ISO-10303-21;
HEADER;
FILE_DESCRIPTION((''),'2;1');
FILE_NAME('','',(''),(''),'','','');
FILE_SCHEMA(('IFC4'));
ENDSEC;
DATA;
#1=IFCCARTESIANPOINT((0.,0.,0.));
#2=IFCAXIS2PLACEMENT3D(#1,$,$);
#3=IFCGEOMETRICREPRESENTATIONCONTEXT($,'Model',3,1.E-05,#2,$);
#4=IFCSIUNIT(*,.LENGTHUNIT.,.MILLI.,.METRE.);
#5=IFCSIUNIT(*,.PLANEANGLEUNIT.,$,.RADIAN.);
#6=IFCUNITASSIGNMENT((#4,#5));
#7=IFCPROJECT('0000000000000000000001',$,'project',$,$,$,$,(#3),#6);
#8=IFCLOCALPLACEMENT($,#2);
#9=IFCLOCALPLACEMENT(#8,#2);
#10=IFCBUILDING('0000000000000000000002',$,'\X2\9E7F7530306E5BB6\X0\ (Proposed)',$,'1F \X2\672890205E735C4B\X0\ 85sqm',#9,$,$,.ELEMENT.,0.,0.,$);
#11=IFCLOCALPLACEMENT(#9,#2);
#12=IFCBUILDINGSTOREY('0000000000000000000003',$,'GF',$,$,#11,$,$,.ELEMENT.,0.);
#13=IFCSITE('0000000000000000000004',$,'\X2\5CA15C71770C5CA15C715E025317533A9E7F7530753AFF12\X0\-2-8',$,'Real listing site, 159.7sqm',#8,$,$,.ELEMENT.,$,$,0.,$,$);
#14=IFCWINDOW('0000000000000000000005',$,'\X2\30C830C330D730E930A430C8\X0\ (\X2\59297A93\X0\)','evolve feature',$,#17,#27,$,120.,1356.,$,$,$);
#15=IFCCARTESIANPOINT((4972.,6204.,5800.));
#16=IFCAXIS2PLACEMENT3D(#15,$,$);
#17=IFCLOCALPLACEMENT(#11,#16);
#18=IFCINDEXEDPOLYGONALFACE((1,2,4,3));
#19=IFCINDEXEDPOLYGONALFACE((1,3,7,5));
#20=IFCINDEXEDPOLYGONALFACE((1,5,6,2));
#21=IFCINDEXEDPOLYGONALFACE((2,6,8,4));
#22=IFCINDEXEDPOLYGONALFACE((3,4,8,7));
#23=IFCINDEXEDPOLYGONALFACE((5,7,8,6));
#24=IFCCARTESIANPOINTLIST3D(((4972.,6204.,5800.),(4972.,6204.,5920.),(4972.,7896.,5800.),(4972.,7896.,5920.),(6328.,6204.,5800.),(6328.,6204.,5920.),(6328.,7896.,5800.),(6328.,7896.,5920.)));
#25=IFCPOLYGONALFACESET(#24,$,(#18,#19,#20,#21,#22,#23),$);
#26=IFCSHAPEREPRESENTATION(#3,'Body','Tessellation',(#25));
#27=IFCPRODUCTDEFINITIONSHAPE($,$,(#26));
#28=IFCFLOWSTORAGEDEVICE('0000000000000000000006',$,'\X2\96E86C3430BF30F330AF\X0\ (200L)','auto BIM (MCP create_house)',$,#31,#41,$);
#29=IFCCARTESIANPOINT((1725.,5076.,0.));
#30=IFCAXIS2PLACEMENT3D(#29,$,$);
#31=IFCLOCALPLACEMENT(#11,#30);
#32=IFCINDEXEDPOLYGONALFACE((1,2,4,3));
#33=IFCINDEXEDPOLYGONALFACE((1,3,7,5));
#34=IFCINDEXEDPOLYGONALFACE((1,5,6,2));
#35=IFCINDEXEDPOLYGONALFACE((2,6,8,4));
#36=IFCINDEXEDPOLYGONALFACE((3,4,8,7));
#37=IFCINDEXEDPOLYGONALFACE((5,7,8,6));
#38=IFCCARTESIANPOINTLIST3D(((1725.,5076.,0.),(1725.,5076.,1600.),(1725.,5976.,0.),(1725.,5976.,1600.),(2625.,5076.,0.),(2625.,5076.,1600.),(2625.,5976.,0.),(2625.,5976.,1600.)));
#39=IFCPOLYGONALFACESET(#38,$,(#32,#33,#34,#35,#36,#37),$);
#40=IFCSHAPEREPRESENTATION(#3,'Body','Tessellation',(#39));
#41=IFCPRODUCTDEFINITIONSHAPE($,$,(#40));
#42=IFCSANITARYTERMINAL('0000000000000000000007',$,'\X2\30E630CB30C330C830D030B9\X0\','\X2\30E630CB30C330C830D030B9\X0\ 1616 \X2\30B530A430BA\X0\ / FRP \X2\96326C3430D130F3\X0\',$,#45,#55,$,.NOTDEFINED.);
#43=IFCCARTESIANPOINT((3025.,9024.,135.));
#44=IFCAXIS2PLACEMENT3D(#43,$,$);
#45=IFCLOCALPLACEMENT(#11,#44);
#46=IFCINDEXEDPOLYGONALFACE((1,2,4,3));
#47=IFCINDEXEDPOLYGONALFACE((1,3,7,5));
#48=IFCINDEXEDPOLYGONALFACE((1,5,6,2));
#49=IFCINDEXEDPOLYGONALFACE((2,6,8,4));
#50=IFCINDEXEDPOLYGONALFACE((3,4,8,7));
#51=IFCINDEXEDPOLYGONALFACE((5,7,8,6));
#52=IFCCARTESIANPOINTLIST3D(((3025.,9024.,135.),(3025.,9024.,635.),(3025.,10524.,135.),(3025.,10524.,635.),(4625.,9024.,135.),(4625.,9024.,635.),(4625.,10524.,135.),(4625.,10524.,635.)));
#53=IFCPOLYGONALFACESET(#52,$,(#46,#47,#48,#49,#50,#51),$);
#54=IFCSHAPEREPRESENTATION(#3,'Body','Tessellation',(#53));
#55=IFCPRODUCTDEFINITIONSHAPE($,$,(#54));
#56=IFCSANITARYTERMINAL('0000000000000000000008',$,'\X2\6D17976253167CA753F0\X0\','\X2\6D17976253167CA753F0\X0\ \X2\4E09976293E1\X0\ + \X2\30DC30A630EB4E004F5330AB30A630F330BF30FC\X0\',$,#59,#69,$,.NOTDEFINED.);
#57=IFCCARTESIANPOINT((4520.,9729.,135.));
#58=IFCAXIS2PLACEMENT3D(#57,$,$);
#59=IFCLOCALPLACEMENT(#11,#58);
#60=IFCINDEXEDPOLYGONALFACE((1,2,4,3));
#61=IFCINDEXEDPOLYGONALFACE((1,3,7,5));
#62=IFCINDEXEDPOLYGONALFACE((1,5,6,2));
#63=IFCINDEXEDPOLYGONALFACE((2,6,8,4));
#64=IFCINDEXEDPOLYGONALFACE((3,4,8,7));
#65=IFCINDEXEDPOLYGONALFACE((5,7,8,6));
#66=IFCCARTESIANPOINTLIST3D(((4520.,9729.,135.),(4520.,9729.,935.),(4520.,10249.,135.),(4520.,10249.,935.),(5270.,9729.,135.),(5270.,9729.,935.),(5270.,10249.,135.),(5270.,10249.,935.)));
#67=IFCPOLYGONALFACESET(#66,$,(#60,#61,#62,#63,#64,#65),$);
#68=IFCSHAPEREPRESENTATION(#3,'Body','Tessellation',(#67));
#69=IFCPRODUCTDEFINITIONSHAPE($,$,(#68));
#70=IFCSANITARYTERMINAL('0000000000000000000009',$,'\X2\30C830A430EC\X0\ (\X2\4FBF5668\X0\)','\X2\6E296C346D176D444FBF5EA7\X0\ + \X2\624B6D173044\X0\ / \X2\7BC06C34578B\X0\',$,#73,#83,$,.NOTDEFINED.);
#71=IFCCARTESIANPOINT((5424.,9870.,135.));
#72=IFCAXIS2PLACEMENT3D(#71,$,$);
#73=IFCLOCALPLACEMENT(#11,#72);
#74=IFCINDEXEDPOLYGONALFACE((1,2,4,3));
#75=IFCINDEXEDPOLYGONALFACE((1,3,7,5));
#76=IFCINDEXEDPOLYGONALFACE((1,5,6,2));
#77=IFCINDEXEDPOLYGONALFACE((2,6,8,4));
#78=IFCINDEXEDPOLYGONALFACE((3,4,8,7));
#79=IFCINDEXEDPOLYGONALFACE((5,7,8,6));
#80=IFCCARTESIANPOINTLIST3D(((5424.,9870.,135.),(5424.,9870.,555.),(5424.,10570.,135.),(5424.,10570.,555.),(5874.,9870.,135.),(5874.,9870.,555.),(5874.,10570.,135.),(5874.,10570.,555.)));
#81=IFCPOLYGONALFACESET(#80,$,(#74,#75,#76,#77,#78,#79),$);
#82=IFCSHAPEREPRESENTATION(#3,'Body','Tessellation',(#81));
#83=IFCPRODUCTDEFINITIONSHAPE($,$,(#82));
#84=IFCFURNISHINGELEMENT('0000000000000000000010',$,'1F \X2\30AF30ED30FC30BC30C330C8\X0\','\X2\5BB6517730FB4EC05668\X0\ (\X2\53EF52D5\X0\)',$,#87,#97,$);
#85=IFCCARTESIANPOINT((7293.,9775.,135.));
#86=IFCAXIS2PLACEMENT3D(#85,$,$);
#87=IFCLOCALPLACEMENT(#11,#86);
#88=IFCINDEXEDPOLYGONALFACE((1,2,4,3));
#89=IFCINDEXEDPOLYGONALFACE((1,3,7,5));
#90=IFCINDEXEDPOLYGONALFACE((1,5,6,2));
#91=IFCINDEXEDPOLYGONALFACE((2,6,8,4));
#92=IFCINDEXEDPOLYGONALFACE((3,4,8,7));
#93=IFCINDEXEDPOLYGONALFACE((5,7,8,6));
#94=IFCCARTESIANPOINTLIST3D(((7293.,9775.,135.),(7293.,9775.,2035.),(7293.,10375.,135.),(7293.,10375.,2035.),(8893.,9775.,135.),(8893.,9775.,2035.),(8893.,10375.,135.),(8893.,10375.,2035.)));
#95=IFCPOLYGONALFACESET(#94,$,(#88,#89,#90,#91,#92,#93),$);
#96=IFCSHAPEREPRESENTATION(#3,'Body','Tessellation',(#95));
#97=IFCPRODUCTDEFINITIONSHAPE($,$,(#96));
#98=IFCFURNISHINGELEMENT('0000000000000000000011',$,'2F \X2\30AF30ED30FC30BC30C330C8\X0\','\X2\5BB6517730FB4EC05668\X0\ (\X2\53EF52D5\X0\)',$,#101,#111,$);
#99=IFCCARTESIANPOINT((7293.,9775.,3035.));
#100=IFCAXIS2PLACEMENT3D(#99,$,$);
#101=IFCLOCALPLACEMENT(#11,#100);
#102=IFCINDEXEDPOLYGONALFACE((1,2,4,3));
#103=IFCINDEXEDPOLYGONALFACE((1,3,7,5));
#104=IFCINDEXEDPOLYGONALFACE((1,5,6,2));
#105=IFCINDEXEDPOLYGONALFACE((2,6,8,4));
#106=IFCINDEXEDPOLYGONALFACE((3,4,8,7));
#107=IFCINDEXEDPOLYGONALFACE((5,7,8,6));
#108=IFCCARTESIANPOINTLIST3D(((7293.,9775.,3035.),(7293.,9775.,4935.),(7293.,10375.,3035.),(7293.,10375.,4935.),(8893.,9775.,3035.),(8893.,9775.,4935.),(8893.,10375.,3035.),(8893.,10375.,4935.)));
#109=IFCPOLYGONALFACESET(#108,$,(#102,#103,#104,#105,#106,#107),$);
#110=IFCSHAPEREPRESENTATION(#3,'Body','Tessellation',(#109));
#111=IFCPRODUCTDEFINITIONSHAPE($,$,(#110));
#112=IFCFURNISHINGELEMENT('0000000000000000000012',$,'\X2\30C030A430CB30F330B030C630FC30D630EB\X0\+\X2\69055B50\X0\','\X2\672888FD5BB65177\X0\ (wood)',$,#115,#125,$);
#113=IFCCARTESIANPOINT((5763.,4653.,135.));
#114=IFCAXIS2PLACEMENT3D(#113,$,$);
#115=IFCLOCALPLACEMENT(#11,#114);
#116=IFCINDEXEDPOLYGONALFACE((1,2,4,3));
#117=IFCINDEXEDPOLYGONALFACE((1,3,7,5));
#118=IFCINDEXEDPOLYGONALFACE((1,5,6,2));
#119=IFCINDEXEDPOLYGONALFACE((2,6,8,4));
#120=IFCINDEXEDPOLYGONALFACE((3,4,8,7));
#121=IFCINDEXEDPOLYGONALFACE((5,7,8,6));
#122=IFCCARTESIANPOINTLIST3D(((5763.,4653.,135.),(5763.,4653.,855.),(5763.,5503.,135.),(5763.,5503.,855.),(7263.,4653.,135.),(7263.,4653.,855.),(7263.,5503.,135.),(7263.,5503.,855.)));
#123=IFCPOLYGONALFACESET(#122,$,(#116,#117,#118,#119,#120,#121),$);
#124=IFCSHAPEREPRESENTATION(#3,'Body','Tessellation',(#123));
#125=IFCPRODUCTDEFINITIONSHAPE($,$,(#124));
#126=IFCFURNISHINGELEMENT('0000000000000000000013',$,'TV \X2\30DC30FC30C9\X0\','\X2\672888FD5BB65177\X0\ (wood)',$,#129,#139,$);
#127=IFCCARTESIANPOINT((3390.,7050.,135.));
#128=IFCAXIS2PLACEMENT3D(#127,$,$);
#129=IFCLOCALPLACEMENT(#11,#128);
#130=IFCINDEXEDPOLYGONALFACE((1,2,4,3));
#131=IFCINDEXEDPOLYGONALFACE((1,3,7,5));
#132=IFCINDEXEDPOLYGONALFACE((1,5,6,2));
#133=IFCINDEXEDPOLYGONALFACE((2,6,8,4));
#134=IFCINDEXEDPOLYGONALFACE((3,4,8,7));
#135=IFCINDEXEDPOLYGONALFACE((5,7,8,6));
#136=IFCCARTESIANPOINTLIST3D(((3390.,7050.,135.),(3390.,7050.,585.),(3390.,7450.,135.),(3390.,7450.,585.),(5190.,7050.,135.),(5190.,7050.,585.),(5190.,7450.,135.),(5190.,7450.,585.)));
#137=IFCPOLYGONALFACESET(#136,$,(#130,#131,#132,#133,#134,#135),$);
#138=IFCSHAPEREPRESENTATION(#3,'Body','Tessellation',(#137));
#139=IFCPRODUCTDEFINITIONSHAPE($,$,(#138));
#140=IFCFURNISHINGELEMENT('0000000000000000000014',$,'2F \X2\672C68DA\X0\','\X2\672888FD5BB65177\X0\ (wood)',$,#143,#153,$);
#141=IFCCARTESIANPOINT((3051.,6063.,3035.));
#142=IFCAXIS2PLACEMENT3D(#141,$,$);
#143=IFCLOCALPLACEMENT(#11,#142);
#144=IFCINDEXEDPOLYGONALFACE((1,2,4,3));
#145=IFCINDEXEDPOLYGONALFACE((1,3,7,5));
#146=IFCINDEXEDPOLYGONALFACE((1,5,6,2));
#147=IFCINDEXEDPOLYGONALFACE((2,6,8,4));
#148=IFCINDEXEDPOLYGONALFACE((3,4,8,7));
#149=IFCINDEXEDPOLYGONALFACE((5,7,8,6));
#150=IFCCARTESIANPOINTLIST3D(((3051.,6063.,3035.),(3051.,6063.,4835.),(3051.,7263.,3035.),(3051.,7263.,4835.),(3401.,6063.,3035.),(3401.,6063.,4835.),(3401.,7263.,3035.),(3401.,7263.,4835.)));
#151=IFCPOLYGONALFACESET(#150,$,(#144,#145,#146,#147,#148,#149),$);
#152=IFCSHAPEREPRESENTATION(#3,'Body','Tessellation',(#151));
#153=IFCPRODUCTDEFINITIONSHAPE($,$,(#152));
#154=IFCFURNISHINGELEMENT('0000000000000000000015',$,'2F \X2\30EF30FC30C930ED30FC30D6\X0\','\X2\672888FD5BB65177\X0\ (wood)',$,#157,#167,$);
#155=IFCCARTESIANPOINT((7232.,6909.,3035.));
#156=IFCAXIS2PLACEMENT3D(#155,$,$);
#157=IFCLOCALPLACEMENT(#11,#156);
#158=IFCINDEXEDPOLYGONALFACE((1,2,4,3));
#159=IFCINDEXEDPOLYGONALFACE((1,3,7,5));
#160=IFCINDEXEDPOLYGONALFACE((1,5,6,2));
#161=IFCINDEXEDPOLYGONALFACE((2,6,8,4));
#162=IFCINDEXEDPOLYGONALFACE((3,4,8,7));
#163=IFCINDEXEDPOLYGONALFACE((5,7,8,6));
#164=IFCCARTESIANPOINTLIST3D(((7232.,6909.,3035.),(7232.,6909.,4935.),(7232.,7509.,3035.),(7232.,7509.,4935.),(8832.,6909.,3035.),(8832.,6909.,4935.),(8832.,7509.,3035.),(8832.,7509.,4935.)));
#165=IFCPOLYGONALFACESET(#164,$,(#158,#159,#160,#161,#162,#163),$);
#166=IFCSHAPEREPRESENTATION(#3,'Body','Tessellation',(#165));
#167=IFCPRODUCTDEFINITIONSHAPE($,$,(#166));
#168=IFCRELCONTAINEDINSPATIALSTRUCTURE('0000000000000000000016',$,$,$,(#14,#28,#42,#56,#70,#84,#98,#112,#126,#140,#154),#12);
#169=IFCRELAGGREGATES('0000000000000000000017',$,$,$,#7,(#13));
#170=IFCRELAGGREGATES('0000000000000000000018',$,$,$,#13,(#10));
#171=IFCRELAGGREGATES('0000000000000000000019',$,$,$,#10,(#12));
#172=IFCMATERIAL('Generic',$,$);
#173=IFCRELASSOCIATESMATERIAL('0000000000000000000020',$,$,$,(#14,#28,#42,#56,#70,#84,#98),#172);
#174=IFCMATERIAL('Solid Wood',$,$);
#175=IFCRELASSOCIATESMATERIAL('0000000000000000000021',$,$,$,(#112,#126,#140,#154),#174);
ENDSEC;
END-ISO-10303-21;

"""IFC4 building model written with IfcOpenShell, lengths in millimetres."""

from ifc_helpers import new_model, si_unit, frame, frame_2d, origin, place, context, project, spatial, rectangle, extrude, material, element, save


model = new_model("IFC4")

# Units and contexts
model_context = context("Model", 3, precision=1e-05, world=origin())
ifc_project = project(units=[si_unit("LENGTHUNIT", "METRE", prefix="MILLI"), si_unit("PLANEANGLEUNIT", "RADIAN")], contexts=[model_context])

# Site, building, storey
site_placement = place(None, origin())
site = spatial("IfcSite", under=ifc_project, at=site_placement, Name="岡山県岡山市北区鹿田町２-2-8", ObjectType="Real listing site, 159.7sqm", CompositionType="ELEMENT", RefElevation=0.0)
building_placement = place(site_placement, origin())
building = spatial("IfcBuilding", under=site, at=building_placement, Name="鹿田の家 (Proposed)", ObjectType="1F 木造平屋 85sqm", CompositionType="ELEMENT", ElevationOfRefHeight=0.0, ElevationOfTerrain=0.0)
storey_placement = place(building_placement, origin())
storey = spatial("IfcBuildingStorey", under=building, at=storey_placement, Name="GF", CompositionType="ELEMENT", Elevation=0.0)

# Shared definitions
ifc_material_1 = material(Name="Solid Wood")

# Window
ifc_material_2 = material(Name="Generic")
window_1_placement = place(storey_placement, frame((4972.0, 6204.0, 5800.0)))
element("IfcWindow", 1, at=window_1_placement, inside=storey, material=ifc_material_2, Name="トップライト (天窓)", Description="evolve feature", OverallHeight=120.0, OverallWidth=1356.0, context=model_context, shape_type="SweptSolid", body=[
    extrude(rectangle(XDim=1356.0, YDim=1692.0, at=frame_2d((678.0, 846.0))), frame((4972.0, 6204.0, 5800.0)), (0.0, 0.0, 1.0), 120.0),
])

# Flow storage device
flow_storage_device_placement = place(storey_placement, frame((1725.0, 5076.0, 0.0)))
element("IfcFlowStorageDevice", 2, at=flow_storage_device_placement, inside=storey, material=ifc_material_2, Name="雨水タンク (200L)", Description="auto BIM (MCP create_house)", context=model_context, shape_type="SweptSolid", body=[
    extrude(rectangle(XDim=900.0, YDim=900.0, at=frame_2d((450.0, 450.0))), frame((1725.0, 5076.0, 0.0)), (0.0, 0.0, 1.0), 1600.0),
])

# Sanitary terminals
sanitary_terminal_1_placement = place(storey_placement, frame((3025.0, 9024.0, 135.0)))
element("IfcSanitaryTerminal", 3, at=sanitary_terminal_1_placement, inside=storey, material=ifc_material_2, Name="ユニットバス", Description="ユニットバス 1616 サイズ / FRP 防水パン", PredefinedType="NOTDEFINED", context=model_context, shape_type="SweptSolid", body=[
    extrude(rectangle(XDim=1600.0, YDim=1500.0, at=frame_2d((800.0, 750.0))), frame((3025.0, 9024.0, 135.0)), (0.0, 0.0, 1.0), 500.0),
])
sanitary_terminal_2_placement = place(storey_placement, frame((4520.0, 9729.0, 135.0)))
element("IfcSanitaryTerminal", 4, at=sanitary_terminal_2_placement, inside=storey, material=ifc_material_2, Name="洗面化粧台", Description="洗面化粧台 三面鏡 + ボウル一体カウンター", PredefinedType="NOTDEFINED", context=model_context, shape_type="SweptSolid", body=[
    extrude(rectangle(XDim=750.0, YDim=520.0, at=frame_2d((375.0, 260.0))), frame((4520.0, 9729.0, 135.0)), (0.0, 0.0, 1.0), 800.0),
])
sanitary_terminal_3_placement = place(storey_placement, frame((5424.0, 9870.0, 135.0)))
element("IfcSanitaryTerminal", 5, at=sanitary_terminal_3_placement, inside=storey, material=ifc_material_2, Name="トイレ (便器)", Description="温水洗浄便座 + 手洗い / 節水型", PredefinedType="NOTDEFINED", context=model_context, shape_type="SweptSolid", body=[
    extrude(rectangle(XDim=450.0, YDim=700.0, at=frame_2d((225.0, 350.0))), frame((5424.0, 9870.0, 135.0)), (0.0, 0.0, 1.0), 420.0),
])

# Furnishing elements
furnishing_1_placement = place(storey_placement, frame((7293.0, 9775.0, 135.0)))
element("IfcFurnishingElement", 6, at=furnishing_1_placement, inside=storey, material=ifc_material_2, Name="1F クローゼット", Description="家具・什器 (可動)", context=model_context, shape_type="SweptSolid", body=[
    extrude(rectangle(XDim=1600.0, YDim=600.0, at=frame_2d((800.0, 300.0))), frame((7293.0, 9775.0, 135.0)), (0.0, 0.0, 1.0), 1900.0),
])
furnishing_2_placement = place(storey_placement, frame((7293.0, 9775.0, 3035.0)))
element("IfcFurnishingElement", 7, at=furnishing_2_placement, inside=storey, material=ifc_material_2, Name="2F クローゼット", Description="家具・什器 (可動)", context=model_context, shape_type="SweptSolid", body=[
    extrude(rectangle(XDim=1600.0, YDim=600.0, at=frame_2d((800.0, 300.0))), frame((7293.0, 9775.0, 3035.0)), (0.0, 0.0, 1.0), 1900.0),
])
furnishing_3_placement = place(storey_placement, frame((5763.0, 4653.0, 135.0)))
element("IfcFurnishingElement", 8, at=furnishing_3_placement, inside=storey, material=ifc_material_1, Name="ダイニングテーブル+椅子", Description="木製家具 (wood)", context=model_context, shape_type="SweptSolid", body=[
    extrude(rectangle(XDim=1500.0, YDim=850.0, at=frame_2d((750.0, 425.0))), frame((5763.0, 4653.0, 135.0)), (0.0, 0.0, 1.0), 720.0),
])
furnishing_4_placement = place(storey_placement, frame((3390.0, 7050.0, 135.0)))
element("IfcFurnishingElement", 9, at=furnishing_4_placement, inside=storey, material=ifc_material_1, Name="TV ボード", Description="木製家具 (wood)", context=model_context, shape_type="SweptSolid", body=[
    extrude(rectangle(XDim=1800.0, YDim=400.0, at=frame_2d((900.0, 200.0))), frame((3390.0, 7050.0, 135.0)), (0.0, 0.0, 1.0), 450.0),
])
furnishing_5_placement = place(storey_placement, frame((3051.0, 6063.0, 3035.0)))
element("IfcFurnishingElement", 10, at=furnishing_5_placement, inside=storey, material=ifc_material_1, Name="2F 本棚", Description="木製家具 (wood)", context=model_context, shape_type="SweptSolid", body=[
    extrude(rectangle(XDim=350.0, YDim=1200.0, at=frame_2d((175.0, 600.0))), frame((3051.0, 6063.0, 3035.0)), (0.0, 0.0, 1.0), 1800.0),
])
furnishing_6_placement = place(storey_placement, frame((7232.0, 6909.0, 3035.0)))
element("IfcFurnishingElement", 11, at=furnishing_6_placement, inside=storey, material=ifc_material_1, Name="2F ワードローブ", Description="木製家具 (wood)", context=model_context, shape_type="SweptSolid", body=[
    extrude(rectangle(XDim=1600.0, YDim=600.0, at=frame_2d((800.0, 300.0))), frame((7232.0, 6909.0, 3035.0)), (0.0, 0.0, 1.0), 1900.0),
])

save(model, "model.ifc")
